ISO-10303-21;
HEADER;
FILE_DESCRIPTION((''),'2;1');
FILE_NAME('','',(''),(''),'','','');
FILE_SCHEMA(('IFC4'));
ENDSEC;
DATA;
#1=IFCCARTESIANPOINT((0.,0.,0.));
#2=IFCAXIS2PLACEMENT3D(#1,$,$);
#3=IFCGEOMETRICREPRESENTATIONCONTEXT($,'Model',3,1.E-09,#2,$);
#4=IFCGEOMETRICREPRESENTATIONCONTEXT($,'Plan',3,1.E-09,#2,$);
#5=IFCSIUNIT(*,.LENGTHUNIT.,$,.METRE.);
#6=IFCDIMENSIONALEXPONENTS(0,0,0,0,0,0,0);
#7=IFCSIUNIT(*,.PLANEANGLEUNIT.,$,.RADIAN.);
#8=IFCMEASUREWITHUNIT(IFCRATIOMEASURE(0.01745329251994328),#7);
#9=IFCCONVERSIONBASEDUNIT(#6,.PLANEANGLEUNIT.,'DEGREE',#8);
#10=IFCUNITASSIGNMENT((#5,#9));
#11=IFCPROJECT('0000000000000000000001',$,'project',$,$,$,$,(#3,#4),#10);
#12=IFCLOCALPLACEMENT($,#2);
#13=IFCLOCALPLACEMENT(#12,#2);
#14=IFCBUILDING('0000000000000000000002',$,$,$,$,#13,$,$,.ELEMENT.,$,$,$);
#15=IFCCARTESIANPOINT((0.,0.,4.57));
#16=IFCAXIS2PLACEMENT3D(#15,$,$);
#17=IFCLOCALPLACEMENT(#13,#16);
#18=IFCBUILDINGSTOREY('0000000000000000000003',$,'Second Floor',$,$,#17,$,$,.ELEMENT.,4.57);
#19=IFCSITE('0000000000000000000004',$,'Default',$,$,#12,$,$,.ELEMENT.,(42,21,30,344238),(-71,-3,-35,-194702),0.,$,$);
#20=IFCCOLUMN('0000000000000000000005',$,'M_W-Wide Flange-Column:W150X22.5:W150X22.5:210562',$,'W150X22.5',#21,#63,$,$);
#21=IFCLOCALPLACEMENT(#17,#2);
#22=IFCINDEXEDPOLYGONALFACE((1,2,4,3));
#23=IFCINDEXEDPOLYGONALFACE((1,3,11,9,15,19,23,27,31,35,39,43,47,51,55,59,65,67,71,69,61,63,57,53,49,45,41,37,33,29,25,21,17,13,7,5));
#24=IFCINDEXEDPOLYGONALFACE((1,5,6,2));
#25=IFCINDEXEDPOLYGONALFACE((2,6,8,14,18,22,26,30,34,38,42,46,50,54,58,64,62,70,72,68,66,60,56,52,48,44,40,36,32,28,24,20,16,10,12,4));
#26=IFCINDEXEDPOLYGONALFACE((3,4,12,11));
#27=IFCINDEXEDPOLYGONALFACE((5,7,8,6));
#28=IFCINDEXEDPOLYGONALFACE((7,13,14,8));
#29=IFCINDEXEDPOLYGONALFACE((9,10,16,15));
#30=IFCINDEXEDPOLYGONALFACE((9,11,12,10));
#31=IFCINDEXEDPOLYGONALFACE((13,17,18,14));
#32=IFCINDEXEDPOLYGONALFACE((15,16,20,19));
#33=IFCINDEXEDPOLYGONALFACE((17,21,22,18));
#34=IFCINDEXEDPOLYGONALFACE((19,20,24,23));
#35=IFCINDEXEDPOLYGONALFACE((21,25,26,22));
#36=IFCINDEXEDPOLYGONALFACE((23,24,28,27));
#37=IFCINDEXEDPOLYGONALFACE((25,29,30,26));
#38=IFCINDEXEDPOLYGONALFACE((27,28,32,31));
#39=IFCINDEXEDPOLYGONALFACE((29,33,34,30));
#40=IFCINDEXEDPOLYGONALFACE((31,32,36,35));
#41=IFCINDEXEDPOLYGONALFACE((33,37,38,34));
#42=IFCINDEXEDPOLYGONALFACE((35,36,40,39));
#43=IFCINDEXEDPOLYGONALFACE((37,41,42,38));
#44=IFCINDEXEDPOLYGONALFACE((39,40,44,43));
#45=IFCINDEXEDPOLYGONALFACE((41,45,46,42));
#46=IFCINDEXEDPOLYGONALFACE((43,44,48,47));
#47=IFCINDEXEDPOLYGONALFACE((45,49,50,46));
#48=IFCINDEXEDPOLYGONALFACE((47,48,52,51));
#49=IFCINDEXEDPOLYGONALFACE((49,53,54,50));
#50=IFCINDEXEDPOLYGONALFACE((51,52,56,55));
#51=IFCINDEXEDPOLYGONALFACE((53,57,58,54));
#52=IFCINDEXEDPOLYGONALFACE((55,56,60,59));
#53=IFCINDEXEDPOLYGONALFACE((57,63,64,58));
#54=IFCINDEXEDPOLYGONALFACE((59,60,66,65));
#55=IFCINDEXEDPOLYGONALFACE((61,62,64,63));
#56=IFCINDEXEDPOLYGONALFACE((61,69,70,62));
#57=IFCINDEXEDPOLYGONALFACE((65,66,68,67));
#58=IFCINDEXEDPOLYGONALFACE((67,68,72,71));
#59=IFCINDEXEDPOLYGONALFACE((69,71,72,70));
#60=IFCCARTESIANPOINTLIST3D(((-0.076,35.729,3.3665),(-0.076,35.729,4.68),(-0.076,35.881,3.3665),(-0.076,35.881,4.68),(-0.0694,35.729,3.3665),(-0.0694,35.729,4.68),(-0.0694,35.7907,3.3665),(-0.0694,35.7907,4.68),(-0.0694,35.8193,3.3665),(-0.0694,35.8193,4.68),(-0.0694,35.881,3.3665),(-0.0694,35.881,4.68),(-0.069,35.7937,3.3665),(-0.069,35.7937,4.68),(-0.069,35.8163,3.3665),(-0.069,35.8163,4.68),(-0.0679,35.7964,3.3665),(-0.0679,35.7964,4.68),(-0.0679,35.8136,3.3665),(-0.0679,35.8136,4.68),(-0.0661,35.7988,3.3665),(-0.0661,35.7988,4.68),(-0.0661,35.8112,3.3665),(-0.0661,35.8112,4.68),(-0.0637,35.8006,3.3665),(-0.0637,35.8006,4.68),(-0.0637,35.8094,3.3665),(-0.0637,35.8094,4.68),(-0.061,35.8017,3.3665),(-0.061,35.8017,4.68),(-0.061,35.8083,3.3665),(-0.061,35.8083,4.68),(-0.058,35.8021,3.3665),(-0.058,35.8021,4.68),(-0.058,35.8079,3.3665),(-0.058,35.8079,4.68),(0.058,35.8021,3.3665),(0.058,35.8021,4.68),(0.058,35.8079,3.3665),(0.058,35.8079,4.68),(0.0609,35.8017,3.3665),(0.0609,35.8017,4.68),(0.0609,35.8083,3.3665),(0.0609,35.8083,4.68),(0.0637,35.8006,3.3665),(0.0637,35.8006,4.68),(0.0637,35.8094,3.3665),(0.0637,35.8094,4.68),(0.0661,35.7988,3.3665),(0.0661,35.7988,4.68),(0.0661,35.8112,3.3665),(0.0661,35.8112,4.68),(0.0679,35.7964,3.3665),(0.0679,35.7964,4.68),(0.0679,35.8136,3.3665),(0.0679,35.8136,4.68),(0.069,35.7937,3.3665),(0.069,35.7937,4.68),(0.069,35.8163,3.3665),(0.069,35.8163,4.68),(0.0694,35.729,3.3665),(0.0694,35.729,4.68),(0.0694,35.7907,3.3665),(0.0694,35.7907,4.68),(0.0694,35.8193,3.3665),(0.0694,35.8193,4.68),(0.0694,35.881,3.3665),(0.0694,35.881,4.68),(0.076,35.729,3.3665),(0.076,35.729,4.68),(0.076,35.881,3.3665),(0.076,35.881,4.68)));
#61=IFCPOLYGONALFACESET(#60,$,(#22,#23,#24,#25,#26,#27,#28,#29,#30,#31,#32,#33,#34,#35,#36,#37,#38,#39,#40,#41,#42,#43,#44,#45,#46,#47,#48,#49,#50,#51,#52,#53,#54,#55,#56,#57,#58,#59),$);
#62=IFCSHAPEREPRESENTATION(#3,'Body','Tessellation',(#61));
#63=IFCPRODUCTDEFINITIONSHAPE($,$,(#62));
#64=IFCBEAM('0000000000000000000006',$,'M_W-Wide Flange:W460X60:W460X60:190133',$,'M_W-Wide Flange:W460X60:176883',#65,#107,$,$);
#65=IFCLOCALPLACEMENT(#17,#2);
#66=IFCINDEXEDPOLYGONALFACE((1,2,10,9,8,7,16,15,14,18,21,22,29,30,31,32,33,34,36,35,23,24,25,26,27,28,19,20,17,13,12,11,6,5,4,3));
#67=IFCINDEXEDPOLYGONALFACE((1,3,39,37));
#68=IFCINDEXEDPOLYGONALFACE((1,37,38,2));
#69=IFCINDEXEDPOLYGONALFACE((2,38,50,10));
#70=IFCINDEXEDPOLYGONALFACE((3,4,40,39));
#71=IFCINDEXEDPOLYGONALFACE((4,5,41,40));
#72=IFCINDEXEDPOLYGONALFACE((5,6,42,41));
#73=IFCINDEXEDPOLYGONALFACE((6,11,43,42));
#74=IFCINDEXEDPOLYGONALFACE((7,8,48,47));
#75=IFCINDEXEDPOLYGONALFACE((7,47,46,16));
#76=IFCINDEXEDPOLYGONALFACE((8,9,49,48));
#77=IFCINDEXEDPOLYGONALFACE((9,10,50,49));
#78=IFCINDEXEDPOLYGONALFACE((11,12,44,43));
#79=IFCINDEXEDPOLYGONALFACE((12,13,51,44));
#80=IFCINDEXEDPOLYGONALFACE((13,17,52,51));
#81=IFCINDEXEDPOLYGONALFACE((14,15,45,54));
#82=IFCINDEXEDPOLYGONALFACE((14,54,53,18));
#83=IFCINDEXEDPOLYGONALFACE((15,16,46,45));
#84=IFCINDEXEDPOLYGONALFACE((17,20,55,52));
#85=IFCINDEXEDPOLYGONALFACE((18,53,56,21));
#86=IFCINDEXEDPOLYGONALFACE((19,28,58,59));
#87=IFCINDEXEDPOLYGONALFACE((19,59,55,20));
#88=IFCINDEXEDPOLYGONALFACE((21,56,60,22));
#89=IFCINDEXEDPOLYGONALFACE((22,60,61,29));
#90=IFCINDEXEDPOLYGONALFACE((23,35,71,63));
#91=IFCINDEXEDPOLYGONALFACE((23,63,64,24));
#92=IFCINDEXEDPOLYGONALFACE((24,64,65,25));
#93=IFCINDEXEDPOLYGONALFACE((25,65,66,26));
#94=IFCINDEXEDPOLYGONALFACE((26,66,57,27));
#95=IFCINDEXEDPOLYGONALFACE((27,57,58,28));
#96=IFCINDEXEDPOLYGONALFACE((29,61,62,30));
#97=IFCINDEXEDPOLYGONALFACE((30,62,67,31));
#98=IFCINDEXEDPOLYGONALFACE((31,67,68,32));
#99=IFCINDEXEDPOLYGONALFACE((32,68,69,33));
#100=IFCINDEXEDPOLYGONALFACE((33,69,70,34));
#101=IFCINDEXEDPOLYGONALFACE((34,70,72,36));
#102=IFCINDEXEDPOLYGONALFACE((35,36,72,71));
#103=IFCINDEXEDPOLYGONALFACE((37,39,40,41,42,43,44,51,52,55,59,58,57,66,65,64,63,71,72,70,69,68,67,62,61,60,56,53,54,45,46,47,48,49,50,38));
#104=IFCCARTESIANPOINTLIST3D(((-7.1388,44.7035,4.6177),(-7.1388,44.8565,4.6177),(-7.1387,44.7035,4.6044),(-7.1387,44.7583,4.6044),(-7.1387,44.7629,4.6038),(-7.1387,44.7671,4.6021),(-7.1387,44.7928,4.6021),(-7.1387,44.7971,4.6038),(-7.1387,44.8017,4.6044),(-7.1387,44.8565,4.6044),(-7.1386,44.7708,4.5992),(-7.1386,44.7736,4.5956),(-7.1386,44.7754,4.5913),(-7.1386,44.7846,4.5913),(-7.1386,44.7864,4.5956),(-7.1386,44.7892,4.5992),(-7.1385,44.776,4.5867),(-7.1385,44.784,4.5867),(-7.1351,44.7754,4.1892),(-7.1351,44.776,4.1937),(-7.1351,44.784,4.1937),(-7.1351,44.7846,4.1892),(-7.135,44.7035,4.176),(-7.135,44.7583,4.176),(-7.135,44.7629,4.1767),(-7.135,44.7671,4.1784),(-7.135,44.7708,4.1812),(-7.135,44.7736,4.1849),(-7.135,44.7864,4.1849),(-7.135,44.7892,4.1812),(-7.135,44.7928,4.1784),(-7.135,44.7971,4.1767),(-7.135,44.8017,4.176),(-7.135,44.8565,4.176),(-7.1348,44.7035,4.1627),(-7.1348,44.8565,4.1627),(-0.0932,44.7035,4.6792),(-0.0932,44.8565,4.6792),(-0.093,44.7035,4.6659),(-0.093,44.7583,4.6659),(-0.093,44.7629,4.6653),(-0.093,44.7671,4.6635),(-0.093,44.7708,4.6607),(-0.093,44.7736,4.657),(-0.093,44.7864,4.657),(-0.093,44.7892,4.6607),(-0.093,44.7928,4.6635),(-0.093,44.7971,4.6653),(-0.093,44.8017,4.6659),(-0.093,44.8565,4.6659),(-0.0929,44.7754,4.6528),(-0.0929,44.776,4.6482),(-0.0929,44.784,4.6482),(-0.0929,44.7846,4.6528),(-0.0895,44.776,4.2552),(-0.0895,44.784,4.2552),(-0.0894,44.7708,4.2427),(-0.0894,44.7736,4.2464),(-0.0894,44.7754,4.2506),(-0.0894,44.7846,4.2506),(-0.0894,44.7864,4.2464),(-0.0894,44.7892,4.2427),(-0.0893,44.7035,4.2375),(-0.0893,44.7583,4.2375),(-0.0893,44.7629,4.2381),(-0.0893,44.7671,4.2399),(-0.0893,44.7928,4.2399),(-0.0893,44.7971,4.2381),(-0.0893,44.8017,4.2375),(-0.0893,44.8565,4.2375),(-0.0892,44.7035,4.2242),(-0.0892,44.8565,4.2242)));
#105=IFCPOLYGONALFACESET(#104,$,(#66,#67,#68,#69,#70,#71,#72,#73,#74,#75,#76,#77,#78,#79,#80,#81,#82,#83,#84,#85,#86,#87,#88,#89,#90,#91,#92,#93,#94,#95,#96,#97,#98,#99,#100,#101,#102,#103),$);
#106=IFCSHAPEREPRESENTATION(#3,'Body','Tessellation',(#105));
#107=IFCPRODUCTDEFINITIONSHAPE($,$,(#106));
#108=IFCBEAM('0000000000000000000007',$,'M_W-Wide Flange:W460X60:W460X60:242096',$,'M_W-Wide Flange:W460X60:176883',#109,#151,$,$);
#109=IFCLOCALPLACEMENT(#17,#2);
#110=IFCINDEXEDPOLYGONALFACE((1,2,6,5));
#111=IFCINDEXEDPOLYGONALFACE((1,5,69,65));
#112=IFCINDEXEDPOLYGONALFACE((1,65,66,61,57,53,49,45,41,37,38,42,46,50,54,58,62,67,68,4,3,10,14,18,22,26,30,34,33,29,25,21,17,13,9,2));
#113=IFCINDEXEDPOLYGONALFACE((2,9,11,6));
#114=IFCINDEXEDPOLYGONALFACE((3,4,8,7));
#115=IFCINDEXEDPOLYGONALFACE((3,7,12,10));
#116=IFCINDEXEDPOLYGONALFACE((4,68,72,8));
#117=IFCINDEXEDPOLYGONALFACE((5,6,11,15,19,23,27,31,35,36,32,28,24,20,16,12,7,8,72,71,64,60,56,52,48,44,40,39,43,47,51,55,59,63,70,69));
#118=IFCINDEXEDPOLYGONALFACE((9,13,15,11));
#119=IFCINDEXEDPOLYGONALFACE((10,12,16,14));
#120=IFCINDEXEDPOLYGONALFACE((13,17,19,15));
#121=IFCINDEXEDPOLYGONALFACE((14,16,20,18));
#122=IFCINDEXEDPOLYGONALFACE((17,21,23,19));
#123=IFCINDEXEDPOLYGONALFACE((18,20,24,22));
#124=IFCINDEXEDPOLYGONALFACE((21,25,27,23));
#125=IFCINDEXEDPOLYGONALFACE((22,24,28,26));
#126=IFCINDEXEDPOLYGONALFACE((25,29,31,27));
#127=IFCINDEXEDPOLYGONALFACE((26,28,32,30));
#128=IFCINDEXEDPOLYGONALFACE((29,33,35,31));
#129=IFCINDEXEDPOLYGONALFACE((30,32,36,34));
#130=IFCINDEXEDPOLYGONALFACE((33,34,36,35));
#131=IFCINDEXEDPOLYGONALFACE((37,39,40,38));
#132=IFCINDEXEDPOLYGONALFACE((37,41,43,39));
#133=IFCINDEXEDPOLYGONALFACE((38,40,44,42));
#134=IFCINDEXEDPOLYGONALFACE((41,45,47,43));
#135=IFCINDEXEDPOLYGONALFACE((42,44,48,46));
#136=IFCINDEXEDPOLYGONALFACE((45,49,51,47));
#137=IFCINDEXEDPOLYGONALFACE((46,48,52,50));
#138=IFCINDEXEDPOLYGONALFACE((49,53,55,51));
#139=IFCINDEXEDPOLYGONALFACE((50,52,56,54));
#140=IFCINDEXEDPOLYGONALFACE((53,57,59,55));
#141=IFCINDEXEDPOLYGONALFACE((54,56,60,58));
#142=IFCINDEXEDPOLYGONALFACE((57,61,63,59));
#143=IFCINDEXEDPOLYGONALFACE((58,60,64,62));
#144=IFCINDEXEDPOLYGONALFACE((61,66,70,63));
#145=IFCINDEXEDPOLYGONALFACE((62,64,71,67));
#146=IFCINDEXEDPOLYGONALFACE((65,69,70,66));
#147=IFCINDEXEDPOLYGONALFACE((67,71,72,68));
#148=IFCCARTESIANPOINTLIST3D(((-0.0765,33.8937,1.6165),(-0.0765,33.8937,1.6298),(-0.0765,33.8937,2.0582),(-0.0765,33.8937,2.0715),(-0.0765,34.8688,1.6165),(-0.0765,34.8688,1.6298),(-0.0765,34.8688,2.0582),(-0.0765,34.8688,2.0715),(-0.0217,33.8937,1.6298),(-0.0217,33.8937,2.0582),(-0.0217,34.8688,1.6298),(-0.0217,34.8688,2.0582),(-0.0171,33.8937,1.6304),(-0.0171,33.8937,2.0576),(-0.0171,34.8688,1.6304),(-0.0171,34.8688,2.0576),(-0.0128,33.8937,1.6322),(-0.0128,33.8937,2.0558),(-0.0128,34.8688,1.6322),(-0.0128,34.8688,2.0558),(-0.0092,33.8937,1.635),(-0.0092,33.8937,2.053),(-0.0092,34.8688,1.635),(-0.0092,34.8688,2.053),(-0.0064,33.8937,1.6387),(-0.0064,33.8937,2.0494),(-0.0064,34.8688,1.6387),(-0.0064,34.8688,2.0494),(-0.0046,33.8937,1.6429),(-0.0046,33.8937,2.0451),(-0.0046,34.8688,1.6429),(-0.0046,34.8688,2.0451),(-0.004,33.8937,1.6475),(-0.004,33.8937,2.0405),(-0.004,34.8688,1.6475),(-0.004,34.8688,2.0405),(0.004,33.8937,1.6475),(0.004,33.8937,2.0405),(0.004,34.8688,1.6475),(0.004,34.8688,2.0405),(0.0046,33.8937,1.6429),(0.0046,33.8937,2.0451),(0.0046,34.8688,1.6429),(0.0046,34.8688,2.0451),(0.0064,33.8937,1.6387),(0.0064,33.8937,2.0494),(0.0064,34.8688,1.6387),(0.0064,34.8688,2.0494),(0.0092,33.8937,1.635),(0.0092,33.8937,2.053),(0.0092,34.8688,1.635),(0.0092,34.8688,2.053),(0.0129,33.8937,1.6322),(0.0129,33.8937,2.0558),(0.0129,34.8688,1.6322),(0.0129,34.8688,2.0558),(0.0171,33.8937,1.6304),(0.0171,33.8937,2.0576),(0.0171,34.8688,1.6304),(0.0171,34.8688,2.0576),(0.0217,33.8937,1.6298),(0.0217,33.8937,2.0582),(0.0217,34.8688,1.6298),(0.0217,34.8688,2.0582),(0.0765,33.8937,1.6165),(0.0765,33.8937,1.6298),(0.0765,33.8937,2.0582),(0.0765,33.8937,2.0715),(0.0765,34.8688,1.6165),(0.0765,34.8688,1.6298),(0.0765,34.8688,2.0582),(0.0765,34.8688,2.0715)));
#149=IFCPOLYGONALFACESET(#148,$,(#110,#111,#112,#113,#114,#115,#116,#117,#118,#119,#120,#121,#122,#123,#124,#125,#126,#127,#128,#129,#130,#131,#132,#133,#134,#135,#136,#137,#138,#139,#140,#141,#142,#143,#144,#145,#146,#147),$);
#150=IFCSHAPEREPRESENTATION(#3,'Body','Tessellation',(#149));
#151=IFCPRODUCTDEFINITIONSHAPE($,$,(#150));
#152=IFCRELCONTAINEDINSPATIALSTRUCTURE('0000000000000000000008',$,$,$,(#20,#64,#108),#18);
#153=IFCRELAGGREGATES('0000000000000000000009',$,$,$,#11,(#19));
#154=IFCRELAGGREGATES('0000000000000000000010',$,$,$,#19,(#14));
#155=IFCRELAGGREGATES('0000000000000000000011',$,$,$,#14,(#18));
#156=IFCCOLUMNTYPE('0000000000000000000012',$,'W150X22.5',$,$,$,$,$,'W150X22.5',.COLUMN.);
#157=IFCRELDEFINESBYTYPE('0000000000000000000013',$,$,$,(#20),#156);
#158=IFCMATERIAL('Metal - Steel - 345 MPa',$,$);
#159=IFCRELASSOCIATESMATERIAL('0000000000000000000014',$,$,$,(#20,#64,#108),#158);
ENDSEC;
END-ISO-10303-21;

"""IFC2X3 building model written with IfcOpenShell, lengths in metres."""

from ifc_helpers import new_model, entity, si_unit, converted_unit, frame, frame_2d, origin, place, context, project, spatial, polyline, circle_curve, parameter, trimmed, segment, composite_curve, outline, extrude, source, transform, mapped, material, type_object, type_shapes, element, save


model = new_model("IFC2X3")

# Units and contexts
model_context = context("Model", 3, precision=1e-09, world=origin())
plan_context = context("Plan", 3, precision=1e-09, world=origin())
ifc_project = project(units=[si_unit("LENGTHUNIT", "METRE"), converted_unit("PLANEANGLEUNIT", "DEGREE", entity("IfcRatioMeasure", 0.01745329251994328), si_unit("PLANEANGLEUNIT", "RADIAN"), dimensions=[0, 0, 0, 0, 0, 0, 0])], contexts=[model_context, plan_context])

# Site, building, storey
site_placement = place(None, origin())
site = spatial("IfcSite", under=ifc_project, at=site_placement, Name="Default", CompositionType="ELEMENT", RefLatitude=(42, 21, 30, 344238), RefLongitude=(-71, -3, -35, -194702), RefElevation=0.0)
building_placement = place(site_placement, origin())
building = spatial("IfcBuilding", under=site, at=building_placement, CompositionType="ELEMENT")
storey_placement = place(building_placement, frame((0.0, 0.0, 4.57)))
storey = spatial("IfcBuildingStorey", under=building, at=storey_placement, Name="Second Floor", CompositionType="ELEMENT", Elevation=4.57)

# Column
ifc_material = material(Name="Metal - Steel - 345 MPa")
column_type_1 = type_object("IfcColumnType", Name="W150X22.5", ElementType="W150X22.5", PredefinedType="COLUMN")
shared_shape_1 = source(origin(), model_context, "Body", "SweptSolid", [
    extrude(outline(composite_curve([segment(polyline([(-0.076, -0.076), (0.076, -0.076)]), True, "CONTINUOUS"), segment(polyline([(0.076, -0.076), (0.076, -0.0694)]), True, "CONTINUOUS"), segment(polyline([(0.076, -0.0694), (0.0143, -0.0694)]), True, "CONTINUOUS"), segment(trimmed(circle_curve(frame_2d((0.0143, -0.058), x_axis=(-1.0, 0.0)), 0.0114), [parameter(0.0)], [parameter(90.0)], True, "PARAMETER"), False, "CONTINUOUS"), segment(polyline([(0.0029, -0.058), (0.0029, 0.058)]), True, "CONTINUOUS"), segment(trimmed(circle_curve(frame_2d((0.0143, 0.058), x_axis=(-1.0, 0.0)), 0.0114), [parameter(270.0)], [parameter(0.0)], True, "PARAMETER"), False, "CONTINUOUS"), segment(polyline([(0.0143, 0.0694), (0.076, 0.0694)]), True, "CONTINUOUS"), segment(polyline([(0.076, 0.0694), (0.076, 0.076)]), True, "CONTINUOUS"), segment(polyline([(0.076, 0.076), (-0.076, 0.076)]), True, "CONTINUOUS"), segment(polyline([(-0.076, 0.076), (-0.076, 0.0694)]), True, "CONTINUOUS"), segment(polyline([(-0.076, 0.0694), (-0.0143, 0.0694)]), True, "CONTINUOUS"), segment(trimmed(circle_curve(frame_2d((-0.0143, 0.058), x_axis=(-1.0, 0.0)), 0.0114), [parameter(180.0)], [parameter(270.0)], True, "PARAMETER"), False, "CONTINUOUS"), segment(polyline([(-0.0029, 0.058), (-0.0029, -0.058)]), True, "CONTINUOUS"), segment(trimmed(circle_curve(frame_2d((-0.0143, -0.058), x_axis=(-1.0, 0.0)), 0.0114), [parameter(90.0)], [parameter(180.0)], True, "PARAMETER"), False, "CONTINUOUS"), segment(polyline([(-0.0143, -0.0694), (-0.076, -0.0694)]), True, "CONTINUOUS"), segment(polyline([(-0.076, -0.0694), (-0.076, -0.076)]), True, "CONTINUOUS")], self_intersect=False)), frame((0.0, 0.0, 7.9365), z_axis=(0.0, 0.0, 1.0), x_axis=(-1.0, 0.0, 0.0)), (0.0, 0.0, 1.0), 1.3135),
])
type_shapes(column_type_1, [shared_shape_1])
column_1_placement = place(storey_placement, frame((0.0, 35.805, -4.57), z_axis=(0.0, 0.0, 1.0), x_axis=(0.0, 1.0, 0.0)))
element("IfcColumn", 1, at=column_1_placement, inside=storey, type_object=column_type_1, material=ifc_material, Name="M_W-Wide Flange-Column:W150X22.5:W150X22.5:210562", ObjectType="W150X22.5", context=model_context, shape_type="MappedRepresentation", body=[
    mapped(shared_shape_1, transform((0.0, 0.0, 0.0), scale=1.0)),
])

# Beams
beam_1_placement = place(storey_placement, frame((-7.2774, 44.78, 4.6165), z_axis=(-0.008722, 0.0, 0.999962), x_axis=(0.0, -1.0, 0.0)))
element("IfcBeam", 2, at=beam_1_placement, inside=storey, material=ifc_material, Name="M_W-Wide Flange:W460X60:W460X60:190133", ObjectType="M_W-Wide Flange:W460X60:176883", context=model_context, shape_type="SweptSolid", body=[
    extrude(outline(composite_curve([segment(polyline([(-0.0765, -0.2142), (-0.0765, -0.2275)]), True, "CONTINUOUS"), segment(polyline([(-0.0765, -0.2275), (0.0765, -0.2275)]), True, "CONTINUOUS"), segment(polyline([(0.0765, -0.2275), (0.0765, -0.2142)]), True, "CONTINUOUS"), segment(polyline([(0.0765, -0.2142), (0.0217, -0.2142)]), True, "CONTINUOUS"), segment(trimmed(circle_curve(frame_2d((0.0217, -0.1965), x_axis=(1.0, 0.0)), 0.0177), [parameter(180.0)], [parameter(270.0)], True, "PARAMETER"), False, "CONTINUOUS"), segment(polyline([(0.004, -0.1965), (0.004, 0.1965)]), True, "CONTINUOUS"), segment(trimmed(circle_curve(frame_2d((0.0217, 0.1965), x_axis=(1.0, 0.0)), 0.0177), [parameter(90.0)], [parameter(180.0)], True, "PARAMETER"), False, "CONTINUOUS"), segment(polyline([(0.0217, 0.2142), (0.0765, 0.2142)]), True, "CONTINUOUS"), segment(polyline([(0.0765, 0.2142), (0.0765, 0.2275)]), True, "CONTINUOUS"), segment(polyline([(0.0765, 0.2275), (-0.0765, 0.2275)]), True, "CONTINUOUS"), segment(polyline([(-0.0765, 0.2275), (-0.0765, 0.2142)]), True, "CONTINUOUS"), segment(polyline([(-0.0765, 0.2142), (-0.0217, 0.2142)]), True, "CONTINUOUS"), segment(trimmed(circle_curve(frame_2d((-0.0217, 0.1965), x_axis=(1.0, 0.0)), 0.0177), [parameter(360.0)], [parameter(90.0)], True, "PARAMETER"), False, "CONTINUOUS"), segment(polyline([(-0.004, 0.1965), (-0.004, -0.1965)]), True, "CONTINUOUS"), segment(trimmed(circle_curve(frame_2d((-0.0217, -0.1965), x_axis=(1.0, 0.0)), 0.0177), [parameter(270.0)], [parameter(0.0)], True, "PARAMETER"), False, "CONTINUOUS"), segment(polyline([(-0.0217, -0.2142), (-0.0765, -0.2142)]), True, "CONTINUOUS")], self_intersect=False)), frame((0.0, 0.1386, -0.2275), z_axis=(0.0, -1.0, 0.0), x_axis=(1.0, 0.0, 0.0)), (0.0, 0.0, -1.0), 7.0459),
])
beam_2_placement = place(storey_placement, frame((0.0, 35.9378, 2.0715)))
element("IfcBeam", 3, at=beam_2_placement, inside=storey, material=ifc_material, Name="M_W-Wide Flange:W460X60:W460X60:242096", ObjectType="M_W-Wide Flange:W460X60:176883", context=model_context, shape_type="SweptSolid", body=[
    extrude(outline(composite_curve([segment(polyline([(0.2142, -0.0765), (0.2275, -0.0765)]), True, "CONTINUOUS"), segment(polyline([(0.2275, -0.0765), (0.2275, 0.0765)]), True, "CONTINUOUS"), segment(polyline([(0.2275, 0.0765), (0.2142, 0.0765)]), True, "CONTINUOUS"), segment(polyline([(0.2142, 0.0765), (0.2142, 0.0217)]), True, "CONTINUOUS"), segment(trimmed(circle_curve(frame_2d((0.1965, 0.0217), x_axis=(0.0, 1.0)), 0.0177), [parameter(180.0)], [parameter(270.0)], True, "PARAMETER"), False, "CONTINUOUS"), segment(polyline([(0.1965, 0.004), (-0.1965, 0.004)]), True, "CONTINUOUS"), segment(trimmed(circle_curve(frame_2d((-0.1965, 0.0217), x_axis=(0.0, 1.0)), 0.0177), [parameter(90.0)], [parameter(180.0)], True, "PARAMETER"), False, "CONTINUOUS"), segment(polyline([(-0.2142, 0.0217), (-0.2142, 0.0765)]), True, "CONTINUOUS"), segment(polyline([(-0.2142, 0.0765), (-0.2275, 0.0765)]), True, "CONTINUOUS"), segment(polyline([(-0.2275, 0.0765), (-0.2275, -0.0765)]), True, "CONTINUOUS"), segment(polyline([(-0.2275, -0.0765), (-0.2142, -0.0765)]), True, "CONTINUOUS"), segment(polyline([(-0.2142, -0.0765), (-0.2142, -0.0217)]), True, "CONTINUOUS"), segment(trimmed(circle_curve(frame_2d((-0.1965, -0.0217), x_axis=(0.0, 1.0)), 0.0177), [parameter(360.0)], [parameter(90.0)], True, "PARAMETER"), False, "CONTINUOUS"), segment(polyline([(-0.1965, -0.004), (0.1965, -0.004)]), True, "CONTINUOUS"), segment(trimmed(circle_curve(frame_2d((0.1965, -0.0217), x_axis=(0.0, 1.0)), 0.0177), [parameter(270.0)], [parameter(0.0)], True, "PARAMETER"), False, "CONTINUOUS"), segment(polyline([(0.2142, -0.0217), (0.2142, -0.0765)]), True, "CONTINUOUS")], self_intersect=False)), frame((0.0, -2.0441, -0.2275), z_axis=(0.0, 1.0, 0.0), x_axis=(0.0, 0.0, -1.0)), (0.0, 0.0, 1.0), 0.9751),
])

save(model, "model.ifc")
